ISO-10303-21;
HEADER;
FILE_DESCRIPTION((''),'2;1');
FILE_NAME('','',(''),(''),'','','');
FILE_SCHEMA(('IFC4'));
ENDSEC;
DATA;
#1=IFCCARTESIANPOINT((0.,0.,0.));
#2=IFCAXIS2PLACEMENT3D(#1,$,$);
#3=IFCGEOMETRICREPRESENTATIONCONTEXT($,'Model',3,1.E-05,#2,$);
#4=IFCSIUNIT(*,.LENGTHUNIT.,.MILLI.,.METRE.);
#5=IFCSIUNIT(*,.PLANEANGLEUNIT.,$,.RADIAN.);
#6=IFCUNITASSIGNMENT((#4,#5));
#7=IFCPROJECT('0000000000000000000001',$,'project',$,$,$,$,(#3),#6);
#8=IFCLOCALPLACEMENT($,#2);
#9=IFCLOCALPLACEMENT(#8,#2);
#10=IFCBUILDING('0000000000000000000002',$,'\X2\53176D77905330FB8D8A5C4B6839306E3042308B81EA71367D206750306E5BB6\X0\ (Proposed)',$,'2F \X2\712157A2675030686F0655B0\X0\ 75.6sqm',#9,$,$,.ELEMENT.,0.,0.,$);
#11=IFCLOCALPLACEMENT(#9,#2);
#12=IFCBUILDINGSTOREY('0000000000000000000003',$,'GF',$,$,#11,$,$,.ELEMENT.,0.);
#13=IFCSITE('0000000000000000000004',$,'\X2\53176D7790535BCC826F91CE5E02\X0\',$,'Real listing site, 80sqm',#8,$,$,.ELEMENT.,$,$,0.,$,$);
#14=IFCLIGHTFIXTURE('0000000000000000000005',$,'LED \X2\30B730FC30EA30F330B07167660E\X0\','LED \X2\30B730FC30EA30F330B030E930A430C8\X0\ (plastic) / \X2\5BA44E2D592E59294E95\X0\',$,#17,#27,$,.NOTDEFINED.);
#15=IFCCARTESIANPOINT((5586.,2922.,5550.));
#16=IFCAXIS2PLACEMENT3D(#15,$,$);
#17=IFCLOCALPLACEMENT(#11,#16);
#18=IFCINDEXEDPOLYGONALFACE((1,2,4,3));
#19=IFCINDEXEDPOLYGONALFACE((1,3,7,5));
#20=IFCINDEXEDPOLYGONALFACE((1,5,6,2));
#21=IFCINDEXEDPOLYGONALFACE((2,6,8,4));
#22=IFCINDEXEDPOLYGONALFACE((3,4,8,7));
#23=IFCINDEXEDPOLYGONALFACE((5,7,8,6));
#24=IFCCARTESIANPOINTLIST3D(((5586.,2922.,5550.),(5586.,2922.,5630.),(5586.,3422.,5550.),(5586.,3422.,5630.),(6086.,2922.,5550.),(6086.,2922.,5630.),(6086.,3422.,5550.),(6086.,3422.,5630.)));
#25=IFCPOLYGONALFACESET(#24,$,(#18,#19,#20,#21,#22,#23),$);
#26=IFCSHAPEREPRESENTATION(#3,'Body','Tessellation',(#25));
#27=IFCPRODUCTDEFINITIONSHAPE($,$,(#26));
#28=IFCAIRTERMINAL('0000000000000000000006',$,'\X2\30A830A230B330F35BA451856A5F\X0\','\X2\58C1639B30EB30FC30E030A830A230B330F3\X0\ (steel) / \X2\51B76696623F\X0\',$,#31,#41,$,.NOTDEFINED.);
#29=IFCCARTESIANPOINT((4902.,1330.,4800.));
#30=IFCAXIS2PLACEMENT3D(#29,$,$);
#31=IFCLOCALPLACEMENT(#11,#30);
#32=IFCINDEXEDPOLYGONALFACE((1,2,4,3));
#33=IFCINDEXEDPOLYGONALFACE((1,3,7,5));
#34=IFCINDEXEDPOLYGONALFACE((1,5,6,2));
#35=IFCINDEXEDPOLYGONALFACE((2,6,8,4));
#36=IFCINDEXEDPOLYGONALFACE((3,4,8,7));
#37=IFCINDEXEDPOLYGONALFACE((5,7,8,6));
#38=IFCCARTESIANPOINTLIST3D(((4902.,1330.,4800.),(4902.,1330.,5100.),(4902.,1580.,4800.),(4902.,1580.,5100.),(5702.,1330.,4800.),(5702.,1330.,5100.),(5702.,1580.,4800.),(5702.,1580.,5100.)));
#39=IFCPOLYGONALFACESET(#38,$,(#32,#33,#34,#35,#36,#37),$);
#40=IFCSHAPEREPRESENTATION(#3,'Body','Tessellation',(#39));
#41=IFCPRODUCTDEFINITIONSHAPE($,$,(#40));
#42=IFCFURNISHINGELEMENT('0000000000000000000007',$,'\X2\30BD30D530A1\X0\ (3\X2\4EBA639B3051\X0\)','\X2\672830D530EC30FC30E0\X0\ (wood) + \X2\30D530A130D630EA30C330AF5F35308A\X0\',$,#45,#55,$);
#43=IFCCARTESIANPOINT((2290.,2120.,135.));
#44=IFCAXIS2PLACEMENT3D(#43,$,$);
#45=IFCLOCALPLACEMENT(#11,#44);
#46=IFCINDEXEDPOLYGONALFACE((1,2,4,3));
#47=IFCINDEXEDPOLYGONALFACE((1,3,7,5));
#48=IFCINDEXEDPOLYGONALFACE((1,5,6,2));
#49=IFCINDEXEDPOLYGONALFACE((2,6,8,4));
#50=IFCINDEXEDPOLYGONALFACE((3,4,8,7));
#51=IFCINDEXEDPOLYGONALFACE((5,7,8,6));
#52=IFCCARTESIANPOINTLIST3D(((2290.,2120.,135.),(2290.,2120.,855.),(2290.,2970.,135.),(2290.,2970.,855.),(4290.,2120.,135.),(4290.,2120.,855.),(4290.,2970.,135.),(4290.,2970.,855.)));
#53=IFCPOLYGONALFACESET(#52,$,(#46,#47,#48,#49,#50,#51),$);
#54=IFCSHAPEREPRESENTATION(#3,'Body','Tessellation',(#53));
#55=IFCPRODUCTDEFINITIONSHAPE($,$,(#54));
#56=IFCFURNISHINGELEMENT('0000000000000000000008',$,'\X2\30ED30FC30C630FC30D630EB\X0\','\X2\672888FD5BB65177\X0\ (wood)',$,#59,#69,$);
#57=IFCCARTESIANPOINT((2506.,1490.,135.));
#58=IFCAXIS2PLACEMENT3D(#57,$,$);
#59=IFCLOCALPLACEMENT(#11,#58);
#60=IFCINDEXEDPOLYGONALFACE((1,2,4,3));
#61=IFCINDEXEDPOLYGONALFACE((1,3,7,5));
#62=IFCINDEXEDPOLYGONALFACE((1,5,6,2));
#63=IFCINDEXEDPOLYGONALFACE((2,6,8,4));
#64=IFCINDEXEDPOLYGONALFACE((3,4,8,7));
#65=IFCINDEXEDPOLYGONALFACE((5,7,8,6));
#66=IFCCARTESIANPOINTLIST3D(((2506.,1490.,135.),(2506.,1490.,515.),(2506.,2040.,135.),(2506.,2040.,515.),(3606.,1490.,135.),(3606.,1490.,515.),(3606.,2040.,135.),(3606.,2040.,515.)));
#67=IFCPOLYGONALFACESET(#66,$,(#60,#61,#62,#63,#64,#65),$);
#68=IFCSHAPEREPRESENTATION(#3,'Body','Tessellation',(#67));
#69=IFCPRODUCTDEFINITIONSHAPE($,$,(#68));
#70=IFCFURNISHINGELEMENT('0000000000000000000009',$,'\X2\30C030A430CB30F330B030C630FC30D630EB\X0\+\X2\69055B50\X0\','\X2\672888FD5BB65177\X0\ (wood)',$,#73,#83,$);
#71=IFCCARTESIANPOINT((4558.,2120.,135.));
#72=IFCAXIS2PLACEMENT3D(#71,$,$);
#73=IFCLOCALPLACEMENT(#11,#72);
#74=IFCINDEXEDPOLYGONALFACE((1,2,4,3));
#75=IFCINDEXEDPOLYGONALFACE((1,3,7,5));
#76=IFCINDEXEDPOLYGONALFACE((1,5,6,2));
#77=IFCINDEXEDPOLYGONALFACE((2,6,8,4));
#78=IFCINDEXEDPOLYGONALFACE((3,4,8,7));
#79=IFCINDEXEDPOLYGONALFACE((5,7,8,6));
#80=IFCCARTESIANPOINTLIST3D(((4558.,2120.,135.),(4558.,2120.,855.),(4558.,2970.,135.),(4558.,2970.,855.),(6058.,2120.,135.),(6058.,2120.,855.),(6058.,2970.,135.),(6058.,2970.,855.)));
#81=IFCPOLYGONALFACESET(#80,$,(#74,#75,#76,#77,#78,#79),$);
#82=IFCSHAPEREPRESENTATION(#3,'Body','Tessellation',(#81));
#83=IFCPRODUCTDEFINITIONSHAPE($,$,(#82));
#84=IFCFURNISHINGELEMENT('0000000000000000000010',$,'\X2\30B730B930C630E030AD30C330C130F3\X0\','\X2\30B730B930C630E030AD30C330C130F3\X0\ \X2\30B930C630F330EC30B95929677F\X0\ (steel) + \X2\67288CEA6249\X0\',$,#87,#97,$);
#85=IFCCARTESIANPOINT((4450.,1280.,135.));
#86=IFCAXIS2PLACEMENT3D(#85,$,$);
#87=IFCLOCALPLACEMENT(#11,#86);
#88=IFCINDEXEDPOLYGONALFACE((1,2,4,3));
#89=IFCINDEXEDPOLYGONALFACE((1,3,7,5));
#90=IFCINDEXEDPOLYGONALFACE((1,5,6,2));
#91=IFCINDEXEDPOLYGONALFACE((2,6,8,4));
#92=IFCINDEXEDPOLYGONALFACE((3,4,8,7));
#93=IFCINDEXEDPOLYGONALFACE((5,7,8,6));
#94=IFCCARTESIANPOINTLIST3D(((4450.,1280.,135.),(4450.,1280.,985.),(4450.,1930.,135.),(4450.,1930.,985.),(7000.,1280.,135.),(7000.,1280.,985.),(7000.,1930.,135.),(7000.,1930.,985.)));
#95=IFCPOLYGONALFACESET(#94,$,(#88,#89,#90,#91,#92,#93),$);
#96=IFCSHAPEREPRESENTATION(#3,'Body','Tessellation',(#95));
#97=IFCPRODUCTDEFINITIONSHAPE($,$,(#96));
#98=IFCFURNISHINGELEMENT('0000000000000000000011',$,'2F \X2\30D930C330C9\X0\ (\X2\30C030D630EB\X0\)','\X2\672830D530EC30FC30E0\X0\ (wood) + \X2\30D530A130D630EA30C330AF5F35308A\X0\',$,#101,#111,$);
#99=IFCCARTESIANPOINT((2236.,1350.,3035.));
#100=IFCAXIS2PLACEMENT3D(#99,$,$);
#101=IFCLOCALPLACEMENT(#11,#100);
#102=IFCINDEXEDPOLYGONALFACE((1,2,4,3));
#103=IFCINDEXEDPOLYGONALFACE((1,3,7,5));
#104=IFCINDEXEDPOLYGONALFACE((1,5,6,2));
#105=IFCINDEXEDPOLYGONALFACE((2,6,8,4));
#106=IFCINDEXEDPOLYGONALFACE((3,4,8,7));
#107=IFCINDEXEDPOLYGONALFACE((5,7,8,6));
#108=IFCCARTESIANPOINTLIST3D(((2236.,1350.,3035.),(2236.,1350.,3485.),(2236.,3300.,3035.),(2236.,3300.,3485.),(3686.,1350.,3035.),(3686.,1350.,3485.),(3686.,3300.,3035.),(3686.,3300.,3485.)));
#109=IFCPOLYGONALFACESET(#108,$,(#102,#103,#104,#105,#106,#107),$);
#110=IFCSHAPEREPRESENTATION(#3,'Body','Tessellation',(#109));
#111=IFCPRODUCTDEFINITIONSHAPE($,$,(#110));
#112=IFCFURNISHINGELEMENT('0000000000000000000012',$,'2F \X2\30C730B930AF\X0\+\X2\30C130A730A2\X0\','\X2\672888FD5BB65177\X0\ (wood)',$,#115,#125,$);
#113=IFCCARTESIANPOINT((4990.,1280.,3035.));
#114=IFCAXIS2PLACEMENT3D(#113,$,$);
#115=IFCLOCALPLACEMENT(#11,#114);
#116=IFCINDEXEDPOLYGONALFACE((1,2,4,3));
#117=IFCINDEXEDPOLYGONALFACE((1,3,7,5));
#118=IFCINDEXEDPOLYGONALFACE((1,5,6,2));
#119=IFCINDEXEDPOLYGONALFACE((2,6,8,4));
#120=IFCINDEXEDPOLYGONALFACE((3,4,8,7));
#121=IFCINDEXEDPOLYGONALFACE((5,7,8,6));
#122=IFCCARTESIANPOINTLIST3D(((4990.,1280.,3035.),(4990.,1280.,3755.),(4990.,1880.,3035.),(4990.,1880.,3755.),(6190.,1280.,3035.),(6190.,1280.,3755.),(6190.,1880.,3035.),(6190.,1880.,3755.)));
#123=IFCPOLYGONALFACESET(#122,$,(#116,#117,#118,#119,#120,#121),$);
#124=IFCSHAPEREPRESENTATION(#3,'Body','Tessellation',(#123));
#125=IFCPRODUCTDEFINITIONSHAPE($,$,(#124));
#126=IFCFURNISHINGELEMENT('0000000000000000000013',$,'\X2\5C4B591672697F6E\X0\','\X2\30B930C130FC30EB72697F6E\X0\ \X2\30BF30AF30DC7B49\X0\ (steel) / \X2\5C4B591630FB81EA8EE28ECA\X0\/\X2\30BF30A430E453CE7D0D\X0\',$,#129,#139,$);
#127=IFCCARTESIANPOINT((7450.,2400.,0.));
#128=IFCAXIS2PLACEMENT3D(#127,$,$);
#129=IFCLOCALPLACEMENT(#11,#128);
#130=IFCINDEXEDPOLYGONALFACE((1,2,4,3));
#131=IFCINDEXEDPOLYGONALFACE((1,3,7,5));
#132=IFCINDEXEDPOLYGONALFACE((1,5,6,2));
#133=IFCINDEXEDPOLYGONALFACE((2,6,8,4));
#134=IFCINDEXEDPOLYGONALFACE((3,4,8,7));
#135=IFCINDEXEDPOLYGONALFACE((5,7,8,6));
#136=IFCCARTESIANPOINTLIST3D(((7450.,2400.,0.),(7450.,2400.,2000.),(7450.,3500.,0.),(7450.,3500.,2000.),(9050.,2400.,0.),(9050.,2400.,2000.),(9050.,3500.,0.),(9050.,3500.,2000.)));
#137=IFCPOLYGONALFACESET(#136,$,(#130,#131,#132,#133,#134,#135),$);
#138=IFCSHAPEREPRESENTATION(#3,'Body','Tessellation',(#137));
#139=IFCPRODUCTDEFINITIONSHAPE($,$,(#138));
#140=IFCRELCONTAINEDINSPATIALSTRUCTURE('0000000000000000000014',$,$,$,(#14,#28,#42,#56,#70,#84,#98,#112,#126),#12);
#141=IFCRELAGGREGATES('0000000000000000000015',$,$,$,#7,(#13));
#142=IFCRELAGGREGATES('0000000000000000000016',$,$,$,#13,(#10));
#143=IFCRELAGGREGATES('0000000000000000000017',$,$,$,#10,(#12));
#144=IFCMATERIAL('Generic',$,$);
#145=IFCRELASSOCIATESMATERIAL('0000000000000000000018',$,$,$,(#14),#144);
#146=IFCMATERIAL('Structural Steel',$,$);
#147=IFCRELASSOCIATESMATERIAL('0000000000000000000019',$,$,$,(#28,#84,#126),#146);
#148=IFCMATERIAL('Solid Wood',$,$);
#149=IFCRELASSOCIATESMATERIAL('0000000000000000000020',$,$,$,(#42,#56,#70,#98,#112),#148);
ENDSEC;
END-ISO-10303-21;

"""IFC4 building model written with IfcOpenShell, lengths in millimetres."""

from ifc_helpers import new_model, si_unit, frame, frame_2d, origin, place, context, project, spatial, rectangle, extrude, material, element, save


model = new_model("IFC4")

# Units and contexts
model_context = context("Model", 3, precision=1e-05, world=origin())
ifc_project = project(units=[si_unit("LENGTHUNIT", "METRE", prefix="MILLI"), si_unit("PLANEANGLEUNIT", "RADIAN")], contexts=[model_context])

# Site, building, storey
site_placement = place(None, origin())
site = spatial("IfcSite", under=ifc_project, at=site_placement, Name="北海道富良野市", ObjectType="Real listing site, 80sqm", CompositionType="ELEMENT", RefElevation=0.0)
building_placement = place(site_placement, origin())
building = spatial("IfcBuilding", under=site, at=building_placement, Name="北海道・越屋根のある自然素材の家 (Proposed)", ObjectType="2F 無垢材と漆喰 75.6sqm", CompositionType="ELEMENT", ElevationOfRefHeight=0.0, ElevationOfTerrain=0.0)
storey_placement = place(building_placement, origin())
storey = spatial("IfcBuildingStorey", under=building, at=storey_placement, Name="GF", CompositionType="ELEMENT", Elevation=0.0)

# Shared definitions
ifc_material_1 = material(Name="Solid Wood")

# Shared definitions
ifc_material_2 = material(Name="Generic")

# Shared definitions
ifc_material_3 = material(Name="Structural Steel")

# Light fixture
light_fixture_placement = place(storey_placement, frame((5586.0, 2922.0, 5550.0)))
element("IfcLightFixture", 1, at=light_fixture_placement, inside=storey, material=ifc_material_2, Name="LED シーリング照明", Description="LED シーリングライト (plastic) / 室中央天井", PredefinedType="NOTDEFINED", context=model_context, shape_type="SweptSolid", body=[
    extrude(rectangle(XDim=500.0, YDim=500.0, at=frame_2d((250.0, 250.0))), frame((5586.0, 2922.0, 5550.0)), (0.0, 0.0, 1.0), 80.0),
])

# Air terminal
air_terminal_1_placement = place(storey_placement, frame((4902.0, 1330.0, 4800.0)))
element("IfcAirTerminal", 2, at=air_terminal_1_placement, inside=storey, material=ifc_material_3, Name="エアコン室内機", Description="壁掛ルームエアコン (steel) / 冷暖房", PredefinedType="NOTDEFINED", context=model_context, shape_type="SweptSolid", body=[
    extrude(rectangle(XDim=800.0, YDim=250.0, at=frame_2d((400.0, 125.0))), frame((4902.0, 1330.0, 4800.0)), (0.0, 0.0, 1.0), 300.0),
])

# Furnishing elements
furnishing_1_placement = place(storey_placement, frame((2290.0, 2120.0, 135.0)))
element("IfcFurnishingElement", 3, at=furnishing_1_placement, inside=storey, material=ifc_material_1, Name="ソファ (3人掛け)", Description="木フレーム (wood) + ファブリック張り", context=model_context, shape_type="SweptSolid", body=[
    extrude(rectangle(XDim=2000.0, YDim=850.0, at=frame_2d((1000.0, 425.0))), frame((2290.0, 2120.0, 135.0)), (0.0, 0.0, 1.0), 720.0),
])
furnishing_2_placement = place(storey_placement, frame((2506.0, 1490.0, 135.0)))
element("IfcFurnishingElement", 4, at=furnishing_2_placement, inside=storey, material=ifc_material_1, Name="ローテーブル", Description="木製家具 (wood)", context=model_context, shape_type="SweptSolid", body=[
    extrude(rectangle(XDim=1100.0, YDim=550.0, at=frame_2d((550.0, 275.0))), frame((2506.0, 1490.0, 135.0)), (0.0, 0.0, 1.0), 380.0),
])
furnishing_3_placement = place(storey_placement, frame((4558.0, 2120.0, 135.0)))
element("IfcFurnishingElement", 5, at=furnishing_3_placement, inside=storey, material=ifc_material_1, Name="ダイニングテーブル+椅子", Description="木製家具 (wood)", context=model_context, shape_type="SweptSolid", body=[
    extrude(rectangle(XDim=1500.0, YDim=850.0, at=frame_2d((750.0, 425.0))), frame((4558.0, 2120.0, 135.0)), (0.0, 0.0, 1.0), 720.0),
])
furnishing_4_placement = place(storey_placement, frame((4450.0, 1280.0, 135.0)))
element("IfcFurnishingElement", 6, at=furnishing_4_placement, inside=storey, material=ifc_material_3, Name="システムキッチン", Description="システムキッチン ステンレス天板 (steel) + 木質扉", context=model_context, shape_type="SweptSolid", body=[
    extrude(rectangle(XDim=2550.0, YDim=650.0, at=frame_2d((1275.0, 325.0))), frame((4450.0, 1280.0, 135.0)), (0.0, 0.0, 1.0), 850.0),
])
furnishing_5_placement = place(storey_placement, frame((2236.0, 1350.0, 3035.0)))
element("IfcFurnishingElement", 7, at=furnishing_5_placement, inside=storey, material=ifc_material_1, Name="2F ベッド (ダブル)", Description="木フレーム (wood) + ファブリック張り", context=model_context, shape_type="SweptSolid", body=[
    extrude(rectangle(XDim=1450.0, YDim=1950.0, at=frame_2d((725.0, 975.0))), frame((2236.0, 1350.0, 3035.0)), (0.0, 0.0, 1.0), 450.0),
])
furnishing_6_placement = place(storey_placement, frame((4990.0, 1280.0, 3035.0)))
element("IfcFurnishingElement", 8, at=furnishing_6_placement, inside=storey, material=ifc_material_1, Name="2F デスク+チェア", Description="木製家具 (wood)", context=model_context, shape_type="SweptSolid", body=[
    extrude(rectangle(XDim=1200.0, YDim=600.0, at=frame_2d((600.0, 300.0))), frame((4990.0, 1280.0, 3035.0)), (0.0, 0.0, 1.0), 720.0),
])
furnishing_7_placement = place(storey_placement, frame((7450.0, 2400.0, 0.0)))
element("IfcFurnishingElement", 9, at=furnishing_7_placement, inside=storey, material=ifc_material_3, Name="屋外物置", Description="スチール物置 タクボ等 (steel) / 屋外・自転車/タイヤ収納", context=model_context, shape_type="SweptSolid", body=[
    extrude(rectangle(XDim=1600.0, YDim=1100.0, at=frame_2d((800.0, 550.0))), frame((7450.0, 2400.0, 0.0)), (0.0, 0.0, 1.0), 2000.0),
])

save(model, "model.ifc")
